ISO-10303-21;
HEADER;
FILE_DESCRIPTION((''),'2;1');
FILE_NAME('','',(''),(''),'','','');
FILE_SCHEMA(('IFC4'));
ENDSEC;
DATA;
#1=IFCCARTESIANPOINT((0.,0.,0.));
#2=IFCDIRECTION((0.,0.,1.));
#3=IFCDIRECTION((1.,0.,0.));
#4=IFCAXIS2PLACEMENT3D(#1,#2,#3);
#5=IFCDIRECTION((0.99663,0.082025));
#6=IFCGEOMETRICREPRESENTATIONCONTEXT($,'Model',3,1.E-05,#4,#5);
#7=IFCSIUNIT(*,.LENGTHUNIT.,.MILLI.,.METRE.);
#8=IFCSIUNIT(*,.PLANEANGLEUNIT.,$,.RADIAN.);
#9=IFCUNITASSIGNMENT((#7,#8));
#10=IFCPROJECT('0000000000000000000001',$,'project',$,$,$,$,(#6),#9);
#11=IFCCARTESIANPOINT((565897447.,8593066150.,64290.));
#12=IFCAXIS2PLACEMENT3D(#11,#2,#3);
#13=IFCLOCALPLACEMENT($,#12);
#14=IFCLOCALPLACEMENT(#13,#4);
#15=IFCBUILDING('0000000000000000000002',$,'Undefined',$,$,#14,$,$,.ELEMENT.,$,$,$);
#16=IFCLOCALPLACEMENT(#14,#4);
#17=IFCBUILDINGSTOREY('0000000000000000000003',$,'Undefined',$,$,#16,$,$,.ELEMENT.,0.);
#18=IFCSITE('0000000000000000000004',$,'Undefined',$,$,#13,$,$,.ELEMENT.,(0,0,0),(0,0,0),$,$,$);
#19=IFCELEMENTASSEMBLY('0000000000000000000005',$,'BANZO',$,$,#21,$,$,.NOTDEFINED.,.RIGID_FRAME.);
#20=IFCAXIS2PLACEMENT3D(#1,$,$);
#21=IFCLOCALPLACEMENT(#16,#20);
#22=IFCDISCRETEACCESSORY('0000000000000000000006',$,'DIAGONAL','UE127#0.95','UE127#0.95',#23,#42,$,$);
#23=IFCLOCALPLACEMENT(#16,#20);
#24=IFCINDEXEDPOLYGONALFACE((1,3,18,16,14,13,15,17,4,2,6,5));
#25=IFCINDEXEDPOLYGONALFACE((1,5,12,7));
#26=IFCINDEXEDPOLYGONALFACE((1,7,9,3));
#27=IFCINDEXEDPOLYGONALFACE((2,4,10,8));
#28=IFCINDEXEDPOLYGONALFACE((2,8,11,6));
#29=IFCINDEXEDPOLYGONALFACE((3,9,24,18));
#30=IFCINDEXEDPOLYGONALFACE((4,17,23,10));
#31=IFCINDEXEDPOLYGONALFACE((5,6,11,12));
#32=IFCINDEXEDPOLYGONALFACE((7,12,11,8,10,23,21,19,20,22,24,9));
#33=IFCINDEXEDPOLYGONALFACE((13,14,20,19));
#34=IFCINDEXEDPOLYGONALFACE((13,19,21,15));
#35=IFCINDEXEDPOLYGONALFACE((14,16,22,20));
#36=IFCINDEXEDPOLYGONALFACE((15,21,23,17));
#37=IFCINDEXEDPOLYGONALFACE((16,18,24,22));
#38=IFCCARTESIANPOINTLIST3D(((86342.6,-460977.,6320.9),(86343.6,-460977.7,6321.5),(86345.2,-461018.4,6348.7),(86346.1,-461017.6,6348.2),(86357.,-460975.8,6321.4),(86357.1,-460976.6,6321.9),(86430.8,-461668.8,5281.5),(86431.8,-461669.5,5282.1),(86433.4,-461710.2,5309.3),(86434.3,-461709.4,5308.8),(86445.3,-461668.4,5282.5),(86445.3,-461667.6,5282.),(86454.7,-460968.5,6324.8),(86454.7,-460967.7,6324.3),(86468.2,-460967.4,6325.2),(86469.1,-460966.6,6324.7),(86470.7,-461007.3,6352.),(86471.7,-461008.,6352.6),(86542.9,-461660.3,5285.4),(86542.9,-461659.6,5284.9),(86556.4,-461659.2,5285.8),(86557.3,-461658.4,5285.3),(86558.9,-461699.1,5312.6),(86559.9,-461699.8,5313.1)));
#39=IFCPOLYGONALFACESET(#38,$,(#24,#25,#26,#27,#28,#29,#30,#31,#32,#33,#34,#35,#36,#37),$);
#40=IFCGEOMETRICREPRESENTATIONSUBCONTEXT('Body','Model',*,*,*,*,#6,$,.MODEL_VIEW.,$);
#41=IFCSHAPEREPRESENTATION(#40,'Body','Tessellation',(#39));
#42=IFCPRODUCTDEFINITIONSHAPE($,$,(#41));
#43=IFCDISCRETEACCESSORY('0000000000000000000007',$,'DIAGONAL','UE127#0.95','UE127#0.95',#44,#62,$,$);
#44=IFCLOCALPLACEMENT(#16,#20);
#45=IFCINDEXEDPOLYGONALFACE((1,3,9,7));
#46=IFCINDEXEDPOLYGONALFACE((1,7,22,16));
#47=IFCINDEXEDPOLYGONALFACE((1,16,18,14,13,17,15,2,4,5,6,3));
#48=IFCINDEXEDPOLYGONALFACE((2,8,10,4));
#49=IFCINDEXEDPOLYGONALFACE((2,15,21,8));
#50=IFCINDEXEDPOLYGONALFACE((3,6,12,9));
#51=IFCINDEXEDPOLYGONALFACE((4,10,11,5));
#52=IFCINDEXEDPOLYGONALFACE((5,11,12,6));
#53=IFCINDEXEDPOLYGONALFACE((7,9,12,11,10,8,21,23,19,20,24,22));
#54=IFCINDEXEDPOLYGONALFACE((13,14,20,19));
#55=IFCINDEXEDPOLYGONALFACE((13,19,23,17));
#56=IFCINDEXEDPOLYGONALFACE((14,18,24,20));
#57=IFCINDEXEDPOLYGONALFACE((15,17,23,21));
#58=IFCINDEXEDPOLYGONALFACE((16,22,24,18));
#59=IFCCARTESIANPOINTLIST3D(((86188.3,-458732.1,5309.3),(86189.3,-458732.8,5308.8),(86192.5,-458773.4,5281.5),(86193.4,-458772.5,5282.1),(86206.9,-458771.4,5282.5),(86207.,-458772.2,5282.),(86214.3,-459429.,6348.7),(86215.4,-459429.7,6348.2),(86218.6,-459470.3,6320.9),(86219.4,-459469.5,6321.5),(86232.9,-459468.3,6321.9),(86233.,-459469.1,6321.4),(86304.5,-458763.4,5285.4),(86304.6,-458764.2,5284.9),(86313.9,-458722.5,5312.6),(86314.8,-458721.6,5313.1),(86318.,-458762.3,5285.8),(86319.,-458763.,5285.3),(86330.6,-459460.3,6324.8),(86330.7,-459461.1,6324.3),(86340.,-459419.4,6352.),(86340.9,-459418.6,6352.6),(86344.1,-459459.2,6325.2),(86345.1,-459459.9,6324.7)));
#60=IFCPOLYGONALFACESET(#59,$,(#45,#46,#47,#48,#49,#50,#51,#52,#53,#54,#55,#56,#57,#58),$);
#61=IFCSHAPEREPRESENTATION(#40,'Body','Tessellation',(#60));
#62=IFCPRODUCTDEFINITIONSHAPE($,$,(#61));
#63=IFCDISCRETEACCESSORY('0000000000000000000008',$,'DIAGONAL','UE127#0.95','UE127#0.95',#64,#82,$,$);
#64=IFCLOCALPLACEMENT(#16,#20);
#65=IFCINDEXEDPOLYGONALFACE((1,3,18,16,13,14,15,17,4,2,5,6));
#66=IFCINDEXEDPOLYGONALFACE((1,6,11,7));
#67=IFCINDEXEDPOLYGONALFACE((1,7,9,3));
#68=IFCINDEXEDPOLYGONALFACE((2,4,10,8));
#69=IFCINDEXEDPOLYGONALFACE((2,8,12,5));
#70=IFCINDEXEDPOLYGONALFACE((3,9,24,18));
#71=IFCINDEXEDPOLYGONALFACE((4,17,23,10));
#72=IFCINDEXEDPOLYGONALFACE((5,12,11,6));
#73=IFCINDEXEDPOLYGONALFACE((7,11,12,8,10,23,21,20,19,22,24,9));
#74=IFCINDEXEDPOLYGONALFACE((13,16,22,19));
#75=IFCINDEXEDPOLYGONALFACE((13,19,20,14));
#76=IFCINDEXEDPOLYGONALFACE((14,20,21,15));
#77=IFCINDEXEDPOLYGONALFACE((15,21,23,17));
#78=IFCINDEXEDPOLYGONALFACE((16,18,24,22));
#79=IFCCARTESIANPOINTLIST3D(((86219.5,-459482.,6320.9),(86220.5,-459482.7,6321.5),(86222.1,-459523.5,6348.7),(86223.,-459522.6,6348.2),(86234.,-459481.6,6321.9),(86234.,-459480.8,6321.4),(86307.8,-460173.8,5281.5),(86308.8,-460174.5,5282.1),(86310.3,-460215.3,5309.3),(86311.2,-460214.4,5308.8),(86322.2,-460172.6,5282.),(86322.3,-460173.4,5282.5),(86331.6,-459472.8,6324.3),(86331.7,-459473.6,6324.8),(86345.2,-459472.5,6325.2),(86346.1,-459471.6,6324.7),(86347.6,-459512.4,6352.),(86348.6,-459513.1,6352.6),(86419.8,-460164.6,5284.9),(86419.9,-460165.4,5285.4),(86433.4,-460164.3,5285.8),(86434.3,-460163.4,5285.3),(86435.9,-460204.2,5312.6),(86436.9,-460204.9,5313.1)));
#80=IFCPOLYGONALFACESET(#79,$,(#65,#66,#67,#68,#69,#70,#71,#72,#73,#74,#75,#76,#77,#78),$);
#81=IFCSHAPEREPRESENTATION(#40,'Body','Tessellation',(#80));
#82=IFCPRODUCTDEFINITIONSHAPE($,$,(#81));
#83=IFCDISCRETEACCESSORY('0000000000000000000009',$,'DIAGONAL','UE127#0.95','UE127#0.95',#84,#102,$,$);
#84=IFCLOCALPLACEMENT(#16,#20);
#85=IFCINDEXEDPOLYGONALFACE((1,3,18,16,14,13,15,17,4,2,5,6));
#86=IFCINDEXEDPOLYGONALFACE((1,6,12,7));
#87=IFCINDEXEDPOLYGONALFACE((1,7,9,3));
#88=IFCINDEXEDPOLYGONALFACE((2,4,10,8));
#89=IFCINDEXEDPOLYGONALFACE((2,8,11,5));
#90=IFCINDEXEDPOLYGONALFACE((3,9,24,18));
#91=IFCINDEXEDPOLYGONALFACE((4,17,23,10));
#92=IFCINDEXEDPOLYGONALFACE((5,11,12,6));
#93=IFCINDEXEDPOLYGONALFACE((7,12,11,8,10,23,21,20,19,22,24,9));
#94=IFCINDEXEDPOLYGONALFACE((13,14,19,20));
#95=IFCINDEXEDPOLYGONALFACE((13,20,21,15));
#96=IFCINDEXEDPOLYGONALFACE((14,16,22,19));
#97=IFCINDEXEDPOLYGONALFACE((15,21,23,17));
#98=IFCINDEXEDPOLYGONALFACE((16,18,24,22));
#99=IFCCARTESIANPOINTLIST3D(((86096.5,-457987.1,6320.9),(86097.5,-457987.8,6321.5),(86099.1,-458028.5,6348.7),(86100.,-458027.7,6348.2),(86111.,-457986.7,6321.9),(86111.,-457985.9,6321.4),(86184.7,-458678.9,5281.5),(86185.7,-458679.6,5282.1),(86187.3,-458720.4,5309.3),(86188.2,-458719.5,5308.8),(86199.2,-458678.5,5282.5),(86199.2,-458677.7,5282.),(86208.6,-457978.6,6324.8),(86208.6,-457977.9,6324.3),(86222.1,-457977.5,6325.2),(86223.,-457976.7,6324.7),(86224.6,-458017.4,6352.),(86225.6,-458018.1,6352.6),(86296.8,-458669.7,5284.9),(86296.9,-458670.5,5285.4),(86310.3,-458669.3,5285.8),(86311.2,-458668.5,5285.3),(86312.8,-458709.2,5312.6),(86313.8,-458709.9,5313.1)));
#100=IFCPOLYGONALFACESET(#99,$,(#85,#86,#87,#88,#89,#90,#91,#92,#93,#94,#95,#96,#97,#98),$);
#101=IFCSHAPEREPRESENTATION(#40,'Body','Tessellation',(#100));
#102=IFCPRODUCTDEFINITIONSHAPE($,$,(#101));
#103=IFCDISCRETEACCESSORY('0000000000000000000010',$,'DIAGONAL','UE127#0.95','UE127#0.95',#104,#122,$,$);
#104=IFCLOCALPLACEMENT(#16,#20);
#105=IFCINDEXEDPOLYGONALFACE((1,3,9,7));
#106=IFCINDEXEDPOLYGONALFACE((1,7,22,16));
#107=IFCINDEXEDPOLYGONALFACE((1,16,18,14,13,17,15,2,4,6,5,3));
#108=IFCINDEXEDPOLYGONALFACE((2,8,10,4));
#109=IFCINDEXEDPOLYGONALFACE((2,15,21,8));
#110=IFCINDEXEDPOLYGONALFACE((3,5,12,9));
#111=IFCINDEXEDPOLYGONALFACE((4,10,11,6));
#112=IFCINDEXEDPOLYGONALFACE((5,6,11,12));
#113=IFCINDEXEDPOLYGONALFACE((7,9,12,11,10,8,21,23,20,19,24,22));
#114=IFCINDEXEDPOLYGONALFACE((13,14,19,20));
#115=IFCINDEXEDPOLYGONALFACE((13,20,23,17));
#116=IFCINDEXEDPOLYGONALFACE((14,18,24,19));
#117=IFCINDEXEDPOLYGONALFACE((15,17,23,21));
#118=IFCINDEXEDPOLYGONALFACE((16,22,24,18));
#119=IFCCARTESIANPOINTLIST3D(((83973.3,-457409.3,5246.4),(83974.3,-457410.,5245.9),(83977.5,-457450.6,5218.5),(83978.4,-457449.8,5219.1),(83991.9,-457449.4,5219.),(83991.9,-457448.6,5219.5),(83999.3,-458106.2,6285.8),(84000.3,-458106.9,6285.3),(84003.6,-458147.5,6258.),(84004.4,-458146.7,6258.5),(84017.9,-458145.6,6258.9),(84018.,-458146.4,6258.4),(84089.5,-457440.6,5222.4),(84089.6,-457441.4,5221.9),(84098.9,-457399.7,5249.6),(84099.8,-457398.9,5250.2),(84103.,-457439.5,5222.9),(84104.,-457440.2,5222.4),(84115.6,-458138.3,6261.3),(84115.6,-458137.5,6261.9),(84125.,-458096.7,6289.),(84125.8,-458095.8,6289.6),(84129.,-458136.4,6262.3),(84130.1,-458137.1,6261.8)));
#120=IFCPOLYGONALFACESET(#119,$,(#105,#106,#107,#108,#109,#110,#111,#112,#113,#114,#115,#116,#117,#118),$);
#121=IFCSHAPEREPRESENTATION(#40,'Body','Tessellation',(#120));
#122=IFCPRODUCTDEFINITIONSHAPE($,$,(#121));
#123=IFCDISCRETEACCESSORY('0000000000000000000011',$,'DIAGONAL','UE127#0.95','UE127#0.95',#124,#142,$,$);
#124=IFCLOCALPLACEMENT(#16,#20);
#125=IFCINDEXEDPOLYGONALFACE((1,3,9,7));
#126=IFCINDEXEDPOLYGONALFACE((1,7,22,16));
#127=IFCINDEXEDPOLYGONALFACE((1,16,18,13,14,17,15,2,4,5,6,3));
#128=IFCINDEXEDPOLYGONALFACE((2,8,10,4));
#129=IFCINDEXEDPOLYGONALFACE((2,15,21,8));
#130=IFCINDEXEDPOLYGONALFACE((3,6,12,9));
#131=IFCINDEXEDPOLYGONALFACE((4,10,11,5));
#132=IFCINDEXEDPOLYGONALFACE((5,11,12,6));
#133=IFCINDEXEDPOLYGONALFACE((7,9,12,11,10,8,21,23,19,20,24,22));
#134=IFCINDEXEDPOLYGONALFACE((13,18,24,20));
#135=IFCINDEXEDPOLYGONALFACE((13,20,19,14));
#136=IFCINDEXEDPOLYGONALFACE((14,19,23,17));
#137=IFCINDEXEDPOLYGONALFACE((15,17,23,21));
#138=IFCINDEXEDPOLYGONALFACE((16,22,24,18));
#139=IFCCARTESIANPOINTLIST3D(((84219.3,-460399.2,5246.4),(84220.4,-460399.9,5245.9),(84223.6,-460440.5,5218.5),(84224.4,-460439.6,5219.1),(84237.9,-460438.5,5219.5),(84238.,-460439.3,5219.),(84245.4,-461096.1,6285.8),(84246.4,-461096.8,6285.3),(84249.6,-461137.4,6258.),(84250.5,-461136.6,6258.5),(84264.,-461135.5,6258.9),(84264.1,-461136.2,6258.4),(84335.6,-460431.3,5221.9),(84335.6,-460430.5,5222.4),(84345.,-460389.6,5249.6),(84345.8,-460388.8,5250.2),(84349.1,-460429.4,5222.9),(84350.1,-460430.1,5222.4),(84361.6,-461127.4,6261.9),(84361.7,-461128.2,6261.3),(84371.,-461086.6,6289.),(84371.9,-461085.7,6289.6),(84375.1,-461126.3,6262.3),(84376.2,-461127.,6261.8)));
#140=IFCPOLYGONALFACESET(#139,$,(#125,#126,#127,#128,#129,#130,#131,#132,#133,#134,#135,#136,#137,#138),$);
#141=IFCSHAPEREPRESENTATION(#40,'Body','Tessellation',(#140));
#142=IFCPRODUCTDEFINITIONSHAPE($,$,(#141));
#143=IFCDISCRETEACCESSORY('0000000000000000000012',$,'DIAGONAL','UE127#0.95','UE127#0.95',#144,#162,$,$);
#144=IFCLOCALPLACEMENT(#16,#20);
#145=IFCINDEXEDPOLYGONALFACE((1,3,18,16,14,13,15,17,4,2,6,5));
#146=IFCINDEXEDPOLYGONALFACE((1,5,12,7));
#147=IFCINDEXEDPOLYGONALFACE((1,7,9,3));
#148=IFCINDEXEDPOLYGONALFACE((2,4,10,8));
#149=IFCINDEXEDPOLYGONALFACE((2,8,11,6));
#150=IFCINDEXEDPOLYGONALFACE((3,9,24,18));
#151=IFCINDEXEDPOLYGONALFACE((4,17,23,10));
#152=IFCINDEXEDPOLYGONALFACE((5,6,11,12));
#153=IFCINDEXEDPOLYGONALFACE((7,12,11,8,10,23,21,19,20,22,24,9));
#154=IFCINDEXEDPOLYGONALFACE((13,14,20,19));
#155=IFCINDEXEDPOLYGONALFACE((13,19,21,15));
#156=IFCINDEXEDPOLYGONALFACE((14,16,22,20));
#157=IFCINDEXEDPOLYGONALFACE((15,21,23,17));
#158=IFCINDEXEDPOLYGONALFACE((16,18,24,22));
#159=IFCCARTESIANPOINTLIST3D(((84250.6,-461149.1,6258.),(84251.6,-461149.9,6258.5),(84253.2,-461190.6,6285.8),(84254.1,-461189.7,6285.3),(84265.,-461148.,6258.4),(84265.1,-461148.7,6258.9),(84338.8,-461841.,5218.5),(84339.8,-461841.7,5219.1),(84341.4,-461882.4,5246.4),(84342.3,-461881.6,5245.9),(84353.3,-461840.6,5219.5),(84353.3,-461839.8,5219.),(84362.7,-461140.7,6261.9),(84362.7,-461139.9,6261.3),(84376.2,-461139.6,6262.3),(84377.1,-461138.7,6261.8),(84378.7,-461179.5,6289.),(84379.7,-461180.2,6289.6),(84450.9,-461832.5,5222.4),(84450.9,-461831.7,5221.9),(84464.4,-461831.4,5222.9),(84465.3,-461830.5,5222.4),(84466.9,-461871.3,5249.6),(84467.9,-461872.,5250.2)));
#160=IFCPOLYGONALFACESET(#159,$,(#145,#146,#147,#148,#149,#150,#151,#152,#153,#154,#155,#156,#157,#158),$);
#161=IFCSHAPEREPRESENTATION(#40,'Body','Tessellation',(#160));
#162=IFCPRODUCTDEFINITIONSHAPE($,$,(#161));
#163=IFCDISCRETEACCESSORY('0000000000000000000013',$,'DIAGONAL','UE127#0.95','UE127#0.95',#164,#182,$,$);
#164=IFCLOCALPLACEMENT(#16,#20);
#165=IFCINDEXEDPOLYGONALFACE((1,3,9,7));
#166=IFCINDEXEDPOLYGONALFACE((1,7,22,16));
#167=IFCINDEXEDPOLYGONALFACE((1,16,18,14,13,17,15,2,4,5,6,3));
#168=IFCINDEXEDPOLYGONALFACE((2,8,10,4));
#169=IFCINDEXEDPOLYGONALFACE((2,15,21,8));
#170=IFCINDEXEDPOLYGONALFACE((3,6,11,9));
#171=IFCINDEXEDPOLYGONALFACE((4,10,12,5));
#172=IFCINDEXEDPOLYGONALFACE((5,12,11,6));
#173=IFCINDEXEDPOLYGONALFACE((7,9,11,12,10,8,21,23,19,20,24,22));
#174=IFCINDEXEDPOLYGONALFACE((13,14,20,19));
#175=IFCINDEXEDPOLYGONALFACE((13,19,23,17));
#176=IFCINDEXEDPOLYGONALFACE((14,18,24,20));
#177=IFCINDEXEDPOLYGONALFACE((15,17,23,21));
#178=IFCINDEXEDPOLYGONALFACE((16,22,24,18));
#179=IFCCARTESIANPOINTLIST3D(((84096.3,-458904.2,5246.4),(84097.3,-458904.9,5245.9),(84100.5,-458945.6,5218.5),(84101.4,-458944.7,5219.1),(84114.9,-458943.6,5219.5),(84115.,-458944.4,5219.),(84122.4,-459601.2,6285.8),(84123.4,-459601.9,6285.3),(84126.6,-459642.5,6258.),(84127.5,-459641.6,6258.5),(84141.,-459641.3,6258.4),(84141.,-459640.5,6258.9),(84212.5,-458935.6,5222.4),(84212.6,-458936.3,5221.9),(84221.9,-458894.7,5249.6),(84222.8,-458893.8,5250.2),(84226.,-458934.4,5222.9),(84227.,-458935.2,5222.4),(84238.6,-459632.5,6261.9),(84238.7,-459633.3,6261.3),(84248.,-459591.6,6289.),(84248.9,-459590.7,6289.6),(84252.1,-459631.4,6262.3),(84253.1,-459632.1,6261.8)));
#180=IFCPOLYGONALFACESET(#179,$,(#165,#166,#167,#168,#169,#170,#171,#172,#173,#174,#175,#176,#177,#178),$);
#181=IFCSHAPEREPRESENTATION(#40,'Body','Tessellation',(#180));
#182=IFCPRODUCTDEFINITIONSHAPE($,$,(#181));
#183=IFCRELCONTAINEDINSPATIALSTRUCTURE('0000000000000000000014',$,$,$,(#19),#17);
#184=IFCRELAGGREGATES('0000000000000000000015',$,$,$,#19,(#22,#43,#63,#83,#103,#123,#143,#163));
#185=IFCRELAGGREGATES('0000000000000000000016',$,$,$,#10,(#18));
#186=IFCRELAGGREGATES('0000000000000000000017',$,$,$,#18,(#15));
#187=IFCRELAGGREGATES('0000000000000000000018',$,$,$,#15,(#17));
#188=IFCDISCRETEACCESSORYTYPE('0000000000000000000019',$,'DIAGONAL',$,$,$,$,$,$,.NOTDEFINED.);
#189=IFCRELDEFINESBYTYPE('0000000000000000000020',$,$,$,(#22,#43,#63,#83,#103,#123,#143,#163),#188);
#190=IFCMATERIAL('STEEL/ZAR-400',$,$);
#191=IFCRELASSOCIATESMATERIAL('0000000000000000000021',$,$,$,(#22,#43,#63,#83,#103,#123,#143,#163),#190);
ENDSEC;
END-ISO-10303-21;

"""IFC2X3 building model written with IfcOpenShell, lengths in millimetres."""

from ifc_helpers import new_model, si_unit, direction, frame, frame_2d, origin_with_axes, place, context, subcontext, project, spatial, c_section, extrude, material, type_object, element, aggregate, save


model = new_model("IFC2X3")

# Units and contexts
model_context = context("Model", 3, precision=1e-05, world=origin_with_axes(), true_north=direction((0.99663, 0.082025)))
body_context = subcontext(model_context, "Body", "Model", "MODEL_VIEW")
ifc_project = project(units=[si_unit("LENGTHUNIT", "METRE", prefix="MILLI"), si_unit("PLANEANGLEUNIT", "RADIAN")], contexts=[model_context])

# Site, building, storey
site_placement = place(None, frame((565897447.0, 8593066150.0, 64290.0), z_axis=(0.0, 0.0, 1.0), x_axis=(1.0, 0.0, 0.0)))
site = spatial("IfcSite", under=ifc_project, at=site_placement, Name="Undefined", CompositionType="ELEMENT", RefLatitude=(0, 0, 0), RefLongitude=(0, 0, 0))
building_placement = place(site_placement, origin_with_axes())
building = spatial("IfcBuilding", under=site, at=building_placement, Name="Undefined", CompositionType="ELEMENT")
storey_placement = place(building_placement, origin_with_axes())
storey = spatial("IfcBuildingStorey", under=building, at=storey_placement, Name="Undefined", CompositionType="ELEMENT", Elevation=0.0)

# Element assembly
assembly_1_placement = place(storey_placement, origin_with_axes())
assembly_1 = element("IfcElementAssembly", 1, at=assembly_1_placement, inside=storey, Name="BANZO", AssemblyPlace="NOTDEFINED", PredefinedType="RIGID_FRAME")

# Discrete accessories
ifc_material_1 = material(Name="STEEL/ZAR-400")
discrete_accessory_type_1 = type_object("IfcDiscreteAccessoryType", Name="DIAGONAL")
discrete_accessory_1_placement = place(assembly_1_placement, frame((86407.1, -460992.5, 6336.7), z_axis=(-0.996182, -0.081989, -0.029987), x_axis=(0.070485, -0.552697, -0.830396)))
discrete_accessory_1 = element("IfcDiscreteAccessory", 2, at=discrete_accessory_1_placement, type_object=discrete_accessory_type_1, material=ifc_material_1, Name="DIAGONAL", Description="UE127#0.95", ObjectType="UE127#0.95", context=body_context, shape_type="SweptSolid", body=[
    extrude(c_section(Depth=127.0, Width=50.0, WallThickness=0.9, Girth=14.5, at=frame_2d((0.0, 0.0), x_axis=(1.0, 0.0))), frame((1251.7, 0.0, 0.0), z_axis=(-1.0, 0.0, 0.0), x_axis=(0.0, -1.0, 0.0)), (0.0, 0.0, 1.0), 1251.7),
])
discrete_accessory_2_placement = place(assembly_1_placement, frame((86253.6, -458747.5, 5297.3), z_axis=(-0.996182, -0.081989, -0.029987), x_axis=(0.020829, -0.556784, 0.830396)))
discrete_accessory_2 = element("IfcDiscreteAccessory", 3, at=discrete_accessory_2_placement, type_object=discrete_accessory_type_1, material=ifc_material_1, Name="DIAGONAL", Description="UE127#0.95", ObjectType="UE127#0.95", context=body_context, shape_type="SweptSolid", body=[
    extrude(c_section(Depth=127.0, Width=50.0, WallThickness=0.9, Girth=14.5, at=frame_2d((0.0, 0.0), x_axis=(1.0, 0.0))), frame((1251.7, 0.0, 0.0), z_axis=(-1.0, 0.0, 0.0), x_axis=(0.0, -1.0, 0.0)), (0.0, 0.0, 1.0), 1251.7),
])
discrete_accessory_3_placement = place(assembly_1_placement, frame((86284.1, -459497.5, 6336.7), z_axis=(-0.996182, -0.081989, -0.029987), x_axis=(0.070485, -0.552697, -0.830396)))
discrete_accessory_3 = element("IfcDiscreteAccessory", 4, at=discrete_accessory_3_placement, type_object=discrete_accessory_type_1, material=ifc_material_1, Name="DIAGONAL", Description="UE127#0.95", ObjectType="UE127#0.95", context=body_context, shape_type="SweptSolid", body=[
    extrude(c_section(Depth=127.0, Width=50.0, WallThickness=0.9, Girth=14.5, at=frame_2d((0.0, 0.0), x_axis=(1.0, 0.0))), frame((1251.7, 0.0, 0.0), z_axis=(-1.0, 0.0, 0.0), x_axis=(0.0, -1.0, 0.0)), (0.0, 0.0, 1.0), 1251.7),
])
discrete_accessory_4_placement = place(assembly_1_placement, frame((86161.1, -458002.6, 6336.7), z_axis=(-0.996182, -0.081989, -0.029987), x_axis=(0.070485, -0.552697, -0.830396)))
discrete_accessory_4 = element("IfcDiscreteAccessory", 5, at=discrete_accessory_4_placement, type_object=discrete_accessory_type_1, material=ifc_material_1, Name="DIAGONAL", Description="UE127#0.95", ObjectType="UE127#0.95", context=body_context, shape_type="SweptSolid", body=[
    extrude(c_section(Depth=127.0, Width=50.0, WallThickness=0.9, Girth=14.5, at=frame_2d((0.0, 0.0), x_axis=(1.0, 0.0))), frame((1251.7, 0.0, 0.0), z_axis=(-1.0, 0.0, 0.0), x_axis=(0.0, -1.0, 0.0)), (0.0, 0.0, 1.0), 1251.7),
])
discrete_accessory_5_placement = place(assembly_1_placement, frame((84038.6, -457424.7, 5234.4), z_axis=(-0.996182, -0.081989, -0.029987), x_axis=(0.020829, -0.556784, 0.830396)))
discrete_accessory_5 = element("IfcDiscreteAccessory", 6, at=discrete_accessory_5_placement, type_object=discrete_accessory_type_1, material=ifc_material_1, Name="DIAGONAL", Description="UE127#0.95", ObjectType="UE127#0.95", context=body_context, shape_type="SweptSolid", body=[
    extrude(c_section(Depth=127.0, Width=50.0, WallThickness=0.9, Girth=14.5, at=frame_2d((0.0, 0.0), x_axis=(1.0, 0.0))), frame((1251.7, 0.0, 0.0), z_axis=(-1.0, 0.0, 0.0), x_axis=(0.0, -1.0, 0.0)), (0.0, 0.0, 1.0), 1251.7),
])
discrete_accessory_6_placement = place(assembly_1_placement, frame((84284.7, -460414.6, 5234.4), z_axis=(-0.996182, -0.081989, -0.029987), x_axis=(0.020829, -0.556784, 0.830396)))
discrete_accessory_6 = element("IfcDiscreteAccessory", 7, at=discrete_accessory_6_placement, type_object=discrete_accessory_type_1, material=ifc_material_1, Name="DIAGONAL", Description="UE127#0.95", ObjectType="UE127#0.95", context=body_context, shape_type="SweptSolid", body=[
    extrude(c_section(Depth=127.0, Width=50.0, WallThickness=0.9, Girth=14.5, at=frame_2d((0.0, 0.0), x_axis=(1.0, 0.0))), frame((1251.7, 0.0, 0.0), z_axis=(-1.0, 0.0, 0.0), x_axis=(0.0, -1.0, 0.0)), (0.0, 0.0, 1.0), 1251.7),
])
discrete_accessory_7_placement = place(assembly_1_placement, frame((84315.1, -461164.7, 6273.8), z_axis=(-0.996182, -0.081989, -0.029987), x_axis=(0.070485, -0.552697, -0.830396)))
discrete_accessory_7 = element("IfcDiscreteAccessory", 8, at=discrete_accessory_7_placement, type_object=discrete_accessory_type_1, material=ifc_material_1, Name="DIAGONAL", Description="UE127#0.95", ObjectType="UE127#0.95", context=body_context, shape_type="SweptSolid", body=[
    extrude(c_section(Depth=127.0, Width=50.0, WallThickness=0.9, Girth=14.5, at=frame_2d((0.0, 0.0), x_axis=(1.0, 0.0))), frame((1251.7, 0.0, 0.0), z_axis=(-1.0, 0.0, 0.0), x_axis=(0.0, -1.0, 0.0)), (0.0, 0.0, 1.0), 1251.7),
])
discrete_accessory_8_placement = place(assembly_1_placement, frame((84161.7, -458919.7, 5234.4), z_axis=(-0.996182, -0.081989, -0.029987), x_axis=(0.020829, -0.556784, 0.830396)))
discrete_accessory_8 = element("IfcDiscreteAccessory", 9, at=discrete_accessory_8_placement, type_object=discrete_accessory_type_1, material=ifc_material_1, Name="DIAGONAL", Description="UE127#0.95", ObjectType="UE127#0.95", context=body_context, shape_type="SweptSolid", body=[
    extrude(c_section(Depth=127.0, Width=50.0, WallThickness=0.9, Girth=14.5, at=frame_2d((0.0, 0.0), x_axis=(1.0, 0.0))), frame((1251.7, 0.0, 0.0), z_axis=(-1.0, 0.0, 0.0), x_axis=(0.0, -1.0, 0.0)), (0.0, 0.0, 1.0), 1251.7),
])
aggregate(assembly_1, [discrete_accessory_1, discrete_accessory_2, discrete_accessory_3, discrete_accessory_4, discrete_accessory_5, discrete_accessory_6, discrete_accessory_7, discrete_accessory_8])

save(model, "model.ifc")
